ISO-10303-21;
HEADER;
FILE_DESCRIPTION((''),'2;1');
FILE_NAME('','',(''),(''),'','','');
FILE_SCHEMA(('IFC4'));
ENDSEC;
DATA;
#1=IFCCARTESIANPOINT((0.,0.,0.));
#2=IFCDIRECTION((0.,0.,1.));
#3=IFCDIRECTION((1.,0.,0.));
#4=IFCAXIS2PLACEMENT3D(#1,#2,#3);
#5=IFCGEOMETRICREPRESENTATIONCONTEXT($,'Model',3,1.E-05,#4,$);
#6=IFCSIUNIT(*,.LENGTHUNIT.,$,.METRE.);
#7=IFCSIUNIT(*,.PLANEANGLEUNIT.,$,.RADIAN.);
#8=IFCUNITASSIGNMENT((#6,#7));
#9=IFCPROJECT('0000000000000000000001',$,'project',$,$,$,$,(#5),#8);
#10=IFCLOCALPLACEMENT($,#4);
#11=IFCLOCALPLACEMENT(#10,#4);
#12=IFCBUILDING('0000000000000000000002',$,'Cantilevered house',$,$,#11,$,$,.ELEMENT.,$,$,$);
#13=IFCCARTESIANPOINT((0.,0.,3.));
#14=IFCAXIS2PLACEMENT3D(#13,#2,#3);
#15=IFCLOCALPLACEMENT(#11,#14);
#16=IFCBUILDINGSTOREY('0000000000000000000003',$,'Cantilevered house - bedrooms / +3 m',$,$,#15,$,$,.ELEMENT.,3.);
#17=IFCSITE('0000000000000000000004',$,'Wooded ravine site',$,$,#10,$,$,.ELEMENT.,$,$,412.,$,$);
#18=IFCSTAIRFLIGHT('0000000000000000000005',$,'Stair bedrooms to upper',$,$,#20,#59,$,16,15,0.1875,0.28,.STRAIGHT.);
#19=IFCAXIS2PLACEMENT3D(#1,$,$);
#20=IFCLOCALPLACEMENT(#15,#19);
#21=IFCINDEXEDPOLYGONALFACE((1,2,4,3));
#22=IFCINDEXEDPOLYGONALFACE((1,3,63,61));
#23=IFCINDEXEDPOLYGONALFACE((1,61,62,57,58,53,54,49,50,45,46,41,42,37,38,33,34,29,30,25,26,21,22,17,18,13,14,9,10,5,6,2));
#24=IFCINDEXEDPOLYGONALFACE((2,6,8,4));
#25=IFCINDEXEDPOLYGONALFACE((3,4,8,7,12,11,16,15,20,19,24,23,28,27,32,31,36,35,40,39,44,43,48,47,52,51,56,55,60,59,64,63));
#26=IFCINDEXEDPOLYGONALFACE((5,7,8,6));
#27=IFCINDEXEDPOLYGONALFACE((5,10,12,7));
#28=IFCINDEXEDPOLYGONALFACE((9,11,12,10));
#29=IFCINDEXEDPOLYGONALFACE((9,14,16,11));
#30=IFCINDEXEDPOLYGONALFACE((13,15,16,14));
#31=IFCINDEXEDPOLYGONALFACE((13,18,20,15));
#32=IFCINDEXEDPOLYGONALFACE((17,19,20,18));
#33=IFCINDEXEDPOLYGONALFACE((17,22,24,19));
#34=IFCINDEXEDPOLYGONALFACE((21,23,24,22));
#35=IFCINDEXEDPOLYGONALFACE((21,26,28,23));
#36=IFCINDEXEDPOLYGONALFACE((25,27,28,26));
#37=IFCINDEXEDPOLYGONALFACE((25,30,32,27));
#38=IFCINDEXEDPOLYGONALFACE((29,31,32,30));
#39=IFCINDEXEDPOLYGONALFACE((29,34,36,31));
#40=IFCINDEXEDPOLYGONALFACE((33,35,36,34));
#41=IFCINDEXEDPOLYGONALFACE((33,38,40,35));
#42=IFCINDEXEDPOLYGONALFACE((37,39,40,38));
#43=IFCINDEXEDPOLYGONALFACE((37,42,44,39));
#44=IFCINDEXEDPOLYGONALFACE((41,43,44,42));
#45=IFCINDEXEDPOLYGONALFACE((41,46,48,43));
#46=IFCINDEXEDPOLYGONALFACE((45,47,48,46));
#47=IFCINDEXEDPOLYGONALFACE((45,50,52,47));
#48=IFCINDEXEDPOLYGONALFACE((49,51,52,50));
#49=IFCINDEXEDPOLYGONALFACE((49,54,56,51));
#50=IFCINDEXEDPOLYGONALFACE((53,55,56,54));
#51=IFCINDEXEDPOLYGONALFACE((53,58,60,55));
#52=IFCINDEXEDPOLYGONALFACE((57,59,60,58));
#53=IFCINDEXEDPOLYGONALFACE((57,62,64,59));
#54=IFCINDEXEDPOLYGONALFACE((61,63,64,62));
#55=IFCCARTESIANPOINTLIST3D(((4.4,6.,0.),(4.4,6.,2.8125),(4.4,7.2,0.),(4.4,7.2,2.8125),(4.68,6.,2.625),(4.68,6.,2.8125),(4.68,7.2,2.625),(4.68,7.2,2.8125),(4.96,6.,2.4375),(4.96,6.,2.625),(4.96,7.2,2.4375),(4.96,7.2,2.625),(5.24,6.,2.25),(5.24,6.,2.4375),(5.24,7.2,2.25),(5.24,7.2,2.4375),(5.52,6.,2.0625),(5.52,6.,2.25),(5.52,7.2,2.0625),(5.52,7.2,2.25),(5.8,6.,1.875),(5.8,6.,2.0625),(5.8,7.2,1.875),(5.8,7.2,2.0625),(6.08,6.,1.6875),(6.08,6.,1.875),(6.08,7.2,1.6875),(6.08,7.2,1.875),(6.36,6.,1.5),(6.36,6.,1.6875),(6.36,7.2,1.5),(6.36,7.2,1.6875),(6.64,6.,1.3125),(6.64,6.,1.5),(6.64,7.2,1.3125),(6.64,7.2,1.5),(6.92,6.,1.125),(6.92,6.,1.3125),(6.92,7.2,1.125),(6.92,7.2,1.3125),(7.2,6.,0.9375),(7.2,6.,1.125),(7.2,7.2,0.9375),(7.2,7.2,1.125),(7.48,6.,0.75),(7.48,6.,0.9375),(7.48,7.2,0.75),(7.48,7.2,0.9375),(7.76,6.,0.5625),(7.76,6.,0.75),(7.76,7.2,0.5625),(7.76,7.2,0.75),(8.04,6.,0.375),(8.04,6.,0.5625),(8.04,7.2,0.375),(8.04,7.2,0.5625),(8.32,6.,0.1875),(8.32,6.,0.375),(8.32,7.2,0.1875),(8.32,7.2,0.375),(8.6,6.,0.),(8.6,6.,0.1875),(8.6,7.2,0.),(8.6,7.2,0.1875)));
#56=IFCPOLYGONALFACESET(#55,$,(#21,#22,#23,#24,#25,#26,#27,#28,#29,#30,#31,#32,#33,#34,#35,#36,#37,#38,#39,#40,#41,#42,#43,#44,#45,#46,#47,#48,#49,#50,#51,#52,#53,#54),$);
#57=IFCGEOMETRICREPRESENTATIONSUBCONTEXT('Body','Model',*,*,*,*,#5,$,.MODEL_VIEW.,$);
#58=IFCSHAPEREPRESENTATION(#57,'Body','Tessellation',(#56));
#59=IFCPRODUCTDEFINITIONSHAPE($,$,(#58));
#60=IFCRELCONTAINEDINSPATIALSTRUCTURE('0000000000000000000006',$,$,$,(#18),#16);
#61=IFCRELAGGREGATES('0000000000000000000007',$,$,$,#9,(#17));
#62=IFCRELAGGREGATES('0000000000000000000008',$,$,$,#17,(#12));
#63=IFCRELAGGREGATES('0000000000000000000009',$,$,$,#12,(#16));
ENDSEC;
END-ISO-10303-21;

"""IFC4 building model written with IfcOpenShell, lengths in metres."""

from ifc_helpers import new_model, si_unit, frame, origin_with_axes, place, context, subcontext, project, spatial, polyline, outline, extrude, element, save


model = new_model("IFC4")

# Units and contexts
model_context = context("Model", 3, precision=1e-05, world=origin_with_axes())
body_context = subcontext(model_context, "Body", "Model", "MODEL_VIEW")
ifc_project = project(units=[si_unit("LENGTHUNIT", "METRE"), si_unit("PLANEANGLEUNIT", "RADIAN")], contexts=[model_context])

# Site, building, storey
site_placement = place(None, origin_with_axes())
site = spatial("IfcSite", under=ifc_project, at=site_placement, Name="Wooded ravine site", CompositionType="ELEMENT", RefElevation=412.0)
building_placement = place(site_placement, origin_with_axes())
building = spatial("IfcBuilding", under=site, at=building_placement, Name="Cantilevered house", CompositionType="ELEMENT")
storey_placement = place(building_placement, frame((0.0, 0.0, 3.0), z_axis=(0.0, 0.0, 1.0), x_axis=(1.0, 0.0, 0.0)))
storey = spatial("IfcBuildingStorey", under=building, at=storey_placement, Name="Cantilevered house - bedrooms / +3 m", CompositionType="ELEMENT", Elevation=3.0)

# Stair flight
stair_flight_placement = place(storey_placement, origin_with_axes())
element("IfcStairFlight", 1, at=stair_flight_placement, inside=storey, Name="Stair bedrooms to upper", NumberOfRisers=16, NumberOfTreads=15, PredefinedType="STRAIGHT", RiserHeight=0.1875, TreadLength=0.28, context=body_context, shape_type="SweptSolid", body=[
    extrude(outline(polyline([(0.0, 0.0), (0.0, 0.1875), (0.28, 0.1875), (0.28, 0.375), (0.56, 0.375), (0.56, 0.5625), (0.84, 0.5625), (0.84, 0.75), (1.12, 0.75), (1.12, 0.9375), (1.4, 0.9375), (1.4, 1.125), (1.68, 1.125), (1.68, 1.3125), (1.96, 1.3125), (1.96, 1.5), (2.24, 1.5), (2.24, 1.6875), (2.52, 1.6875), (2.52, 1.875), (2.8, 1.875), (2.8, 2.0625), (3.08, 2.0625), (3.08, 2.25), (3.36, 2.25), (3.36, 2.4375), (3.64, 2.4375), (3.64, 2.625), (3.92, 2.625), (3.92, 2.8125), (4.2, 2.8125), (4.2, 3.0), (4.2, 0.0), (0.0, 0.0)])), frame((8.6, 6.0, 0.0), z_axis=(0.0, 1.0, 0.0), x_axis=(-1.0, 0.0, 0.0)), (0.0, 0.0, 1.0), 1.2),
])

save(model, "model.ifc")
